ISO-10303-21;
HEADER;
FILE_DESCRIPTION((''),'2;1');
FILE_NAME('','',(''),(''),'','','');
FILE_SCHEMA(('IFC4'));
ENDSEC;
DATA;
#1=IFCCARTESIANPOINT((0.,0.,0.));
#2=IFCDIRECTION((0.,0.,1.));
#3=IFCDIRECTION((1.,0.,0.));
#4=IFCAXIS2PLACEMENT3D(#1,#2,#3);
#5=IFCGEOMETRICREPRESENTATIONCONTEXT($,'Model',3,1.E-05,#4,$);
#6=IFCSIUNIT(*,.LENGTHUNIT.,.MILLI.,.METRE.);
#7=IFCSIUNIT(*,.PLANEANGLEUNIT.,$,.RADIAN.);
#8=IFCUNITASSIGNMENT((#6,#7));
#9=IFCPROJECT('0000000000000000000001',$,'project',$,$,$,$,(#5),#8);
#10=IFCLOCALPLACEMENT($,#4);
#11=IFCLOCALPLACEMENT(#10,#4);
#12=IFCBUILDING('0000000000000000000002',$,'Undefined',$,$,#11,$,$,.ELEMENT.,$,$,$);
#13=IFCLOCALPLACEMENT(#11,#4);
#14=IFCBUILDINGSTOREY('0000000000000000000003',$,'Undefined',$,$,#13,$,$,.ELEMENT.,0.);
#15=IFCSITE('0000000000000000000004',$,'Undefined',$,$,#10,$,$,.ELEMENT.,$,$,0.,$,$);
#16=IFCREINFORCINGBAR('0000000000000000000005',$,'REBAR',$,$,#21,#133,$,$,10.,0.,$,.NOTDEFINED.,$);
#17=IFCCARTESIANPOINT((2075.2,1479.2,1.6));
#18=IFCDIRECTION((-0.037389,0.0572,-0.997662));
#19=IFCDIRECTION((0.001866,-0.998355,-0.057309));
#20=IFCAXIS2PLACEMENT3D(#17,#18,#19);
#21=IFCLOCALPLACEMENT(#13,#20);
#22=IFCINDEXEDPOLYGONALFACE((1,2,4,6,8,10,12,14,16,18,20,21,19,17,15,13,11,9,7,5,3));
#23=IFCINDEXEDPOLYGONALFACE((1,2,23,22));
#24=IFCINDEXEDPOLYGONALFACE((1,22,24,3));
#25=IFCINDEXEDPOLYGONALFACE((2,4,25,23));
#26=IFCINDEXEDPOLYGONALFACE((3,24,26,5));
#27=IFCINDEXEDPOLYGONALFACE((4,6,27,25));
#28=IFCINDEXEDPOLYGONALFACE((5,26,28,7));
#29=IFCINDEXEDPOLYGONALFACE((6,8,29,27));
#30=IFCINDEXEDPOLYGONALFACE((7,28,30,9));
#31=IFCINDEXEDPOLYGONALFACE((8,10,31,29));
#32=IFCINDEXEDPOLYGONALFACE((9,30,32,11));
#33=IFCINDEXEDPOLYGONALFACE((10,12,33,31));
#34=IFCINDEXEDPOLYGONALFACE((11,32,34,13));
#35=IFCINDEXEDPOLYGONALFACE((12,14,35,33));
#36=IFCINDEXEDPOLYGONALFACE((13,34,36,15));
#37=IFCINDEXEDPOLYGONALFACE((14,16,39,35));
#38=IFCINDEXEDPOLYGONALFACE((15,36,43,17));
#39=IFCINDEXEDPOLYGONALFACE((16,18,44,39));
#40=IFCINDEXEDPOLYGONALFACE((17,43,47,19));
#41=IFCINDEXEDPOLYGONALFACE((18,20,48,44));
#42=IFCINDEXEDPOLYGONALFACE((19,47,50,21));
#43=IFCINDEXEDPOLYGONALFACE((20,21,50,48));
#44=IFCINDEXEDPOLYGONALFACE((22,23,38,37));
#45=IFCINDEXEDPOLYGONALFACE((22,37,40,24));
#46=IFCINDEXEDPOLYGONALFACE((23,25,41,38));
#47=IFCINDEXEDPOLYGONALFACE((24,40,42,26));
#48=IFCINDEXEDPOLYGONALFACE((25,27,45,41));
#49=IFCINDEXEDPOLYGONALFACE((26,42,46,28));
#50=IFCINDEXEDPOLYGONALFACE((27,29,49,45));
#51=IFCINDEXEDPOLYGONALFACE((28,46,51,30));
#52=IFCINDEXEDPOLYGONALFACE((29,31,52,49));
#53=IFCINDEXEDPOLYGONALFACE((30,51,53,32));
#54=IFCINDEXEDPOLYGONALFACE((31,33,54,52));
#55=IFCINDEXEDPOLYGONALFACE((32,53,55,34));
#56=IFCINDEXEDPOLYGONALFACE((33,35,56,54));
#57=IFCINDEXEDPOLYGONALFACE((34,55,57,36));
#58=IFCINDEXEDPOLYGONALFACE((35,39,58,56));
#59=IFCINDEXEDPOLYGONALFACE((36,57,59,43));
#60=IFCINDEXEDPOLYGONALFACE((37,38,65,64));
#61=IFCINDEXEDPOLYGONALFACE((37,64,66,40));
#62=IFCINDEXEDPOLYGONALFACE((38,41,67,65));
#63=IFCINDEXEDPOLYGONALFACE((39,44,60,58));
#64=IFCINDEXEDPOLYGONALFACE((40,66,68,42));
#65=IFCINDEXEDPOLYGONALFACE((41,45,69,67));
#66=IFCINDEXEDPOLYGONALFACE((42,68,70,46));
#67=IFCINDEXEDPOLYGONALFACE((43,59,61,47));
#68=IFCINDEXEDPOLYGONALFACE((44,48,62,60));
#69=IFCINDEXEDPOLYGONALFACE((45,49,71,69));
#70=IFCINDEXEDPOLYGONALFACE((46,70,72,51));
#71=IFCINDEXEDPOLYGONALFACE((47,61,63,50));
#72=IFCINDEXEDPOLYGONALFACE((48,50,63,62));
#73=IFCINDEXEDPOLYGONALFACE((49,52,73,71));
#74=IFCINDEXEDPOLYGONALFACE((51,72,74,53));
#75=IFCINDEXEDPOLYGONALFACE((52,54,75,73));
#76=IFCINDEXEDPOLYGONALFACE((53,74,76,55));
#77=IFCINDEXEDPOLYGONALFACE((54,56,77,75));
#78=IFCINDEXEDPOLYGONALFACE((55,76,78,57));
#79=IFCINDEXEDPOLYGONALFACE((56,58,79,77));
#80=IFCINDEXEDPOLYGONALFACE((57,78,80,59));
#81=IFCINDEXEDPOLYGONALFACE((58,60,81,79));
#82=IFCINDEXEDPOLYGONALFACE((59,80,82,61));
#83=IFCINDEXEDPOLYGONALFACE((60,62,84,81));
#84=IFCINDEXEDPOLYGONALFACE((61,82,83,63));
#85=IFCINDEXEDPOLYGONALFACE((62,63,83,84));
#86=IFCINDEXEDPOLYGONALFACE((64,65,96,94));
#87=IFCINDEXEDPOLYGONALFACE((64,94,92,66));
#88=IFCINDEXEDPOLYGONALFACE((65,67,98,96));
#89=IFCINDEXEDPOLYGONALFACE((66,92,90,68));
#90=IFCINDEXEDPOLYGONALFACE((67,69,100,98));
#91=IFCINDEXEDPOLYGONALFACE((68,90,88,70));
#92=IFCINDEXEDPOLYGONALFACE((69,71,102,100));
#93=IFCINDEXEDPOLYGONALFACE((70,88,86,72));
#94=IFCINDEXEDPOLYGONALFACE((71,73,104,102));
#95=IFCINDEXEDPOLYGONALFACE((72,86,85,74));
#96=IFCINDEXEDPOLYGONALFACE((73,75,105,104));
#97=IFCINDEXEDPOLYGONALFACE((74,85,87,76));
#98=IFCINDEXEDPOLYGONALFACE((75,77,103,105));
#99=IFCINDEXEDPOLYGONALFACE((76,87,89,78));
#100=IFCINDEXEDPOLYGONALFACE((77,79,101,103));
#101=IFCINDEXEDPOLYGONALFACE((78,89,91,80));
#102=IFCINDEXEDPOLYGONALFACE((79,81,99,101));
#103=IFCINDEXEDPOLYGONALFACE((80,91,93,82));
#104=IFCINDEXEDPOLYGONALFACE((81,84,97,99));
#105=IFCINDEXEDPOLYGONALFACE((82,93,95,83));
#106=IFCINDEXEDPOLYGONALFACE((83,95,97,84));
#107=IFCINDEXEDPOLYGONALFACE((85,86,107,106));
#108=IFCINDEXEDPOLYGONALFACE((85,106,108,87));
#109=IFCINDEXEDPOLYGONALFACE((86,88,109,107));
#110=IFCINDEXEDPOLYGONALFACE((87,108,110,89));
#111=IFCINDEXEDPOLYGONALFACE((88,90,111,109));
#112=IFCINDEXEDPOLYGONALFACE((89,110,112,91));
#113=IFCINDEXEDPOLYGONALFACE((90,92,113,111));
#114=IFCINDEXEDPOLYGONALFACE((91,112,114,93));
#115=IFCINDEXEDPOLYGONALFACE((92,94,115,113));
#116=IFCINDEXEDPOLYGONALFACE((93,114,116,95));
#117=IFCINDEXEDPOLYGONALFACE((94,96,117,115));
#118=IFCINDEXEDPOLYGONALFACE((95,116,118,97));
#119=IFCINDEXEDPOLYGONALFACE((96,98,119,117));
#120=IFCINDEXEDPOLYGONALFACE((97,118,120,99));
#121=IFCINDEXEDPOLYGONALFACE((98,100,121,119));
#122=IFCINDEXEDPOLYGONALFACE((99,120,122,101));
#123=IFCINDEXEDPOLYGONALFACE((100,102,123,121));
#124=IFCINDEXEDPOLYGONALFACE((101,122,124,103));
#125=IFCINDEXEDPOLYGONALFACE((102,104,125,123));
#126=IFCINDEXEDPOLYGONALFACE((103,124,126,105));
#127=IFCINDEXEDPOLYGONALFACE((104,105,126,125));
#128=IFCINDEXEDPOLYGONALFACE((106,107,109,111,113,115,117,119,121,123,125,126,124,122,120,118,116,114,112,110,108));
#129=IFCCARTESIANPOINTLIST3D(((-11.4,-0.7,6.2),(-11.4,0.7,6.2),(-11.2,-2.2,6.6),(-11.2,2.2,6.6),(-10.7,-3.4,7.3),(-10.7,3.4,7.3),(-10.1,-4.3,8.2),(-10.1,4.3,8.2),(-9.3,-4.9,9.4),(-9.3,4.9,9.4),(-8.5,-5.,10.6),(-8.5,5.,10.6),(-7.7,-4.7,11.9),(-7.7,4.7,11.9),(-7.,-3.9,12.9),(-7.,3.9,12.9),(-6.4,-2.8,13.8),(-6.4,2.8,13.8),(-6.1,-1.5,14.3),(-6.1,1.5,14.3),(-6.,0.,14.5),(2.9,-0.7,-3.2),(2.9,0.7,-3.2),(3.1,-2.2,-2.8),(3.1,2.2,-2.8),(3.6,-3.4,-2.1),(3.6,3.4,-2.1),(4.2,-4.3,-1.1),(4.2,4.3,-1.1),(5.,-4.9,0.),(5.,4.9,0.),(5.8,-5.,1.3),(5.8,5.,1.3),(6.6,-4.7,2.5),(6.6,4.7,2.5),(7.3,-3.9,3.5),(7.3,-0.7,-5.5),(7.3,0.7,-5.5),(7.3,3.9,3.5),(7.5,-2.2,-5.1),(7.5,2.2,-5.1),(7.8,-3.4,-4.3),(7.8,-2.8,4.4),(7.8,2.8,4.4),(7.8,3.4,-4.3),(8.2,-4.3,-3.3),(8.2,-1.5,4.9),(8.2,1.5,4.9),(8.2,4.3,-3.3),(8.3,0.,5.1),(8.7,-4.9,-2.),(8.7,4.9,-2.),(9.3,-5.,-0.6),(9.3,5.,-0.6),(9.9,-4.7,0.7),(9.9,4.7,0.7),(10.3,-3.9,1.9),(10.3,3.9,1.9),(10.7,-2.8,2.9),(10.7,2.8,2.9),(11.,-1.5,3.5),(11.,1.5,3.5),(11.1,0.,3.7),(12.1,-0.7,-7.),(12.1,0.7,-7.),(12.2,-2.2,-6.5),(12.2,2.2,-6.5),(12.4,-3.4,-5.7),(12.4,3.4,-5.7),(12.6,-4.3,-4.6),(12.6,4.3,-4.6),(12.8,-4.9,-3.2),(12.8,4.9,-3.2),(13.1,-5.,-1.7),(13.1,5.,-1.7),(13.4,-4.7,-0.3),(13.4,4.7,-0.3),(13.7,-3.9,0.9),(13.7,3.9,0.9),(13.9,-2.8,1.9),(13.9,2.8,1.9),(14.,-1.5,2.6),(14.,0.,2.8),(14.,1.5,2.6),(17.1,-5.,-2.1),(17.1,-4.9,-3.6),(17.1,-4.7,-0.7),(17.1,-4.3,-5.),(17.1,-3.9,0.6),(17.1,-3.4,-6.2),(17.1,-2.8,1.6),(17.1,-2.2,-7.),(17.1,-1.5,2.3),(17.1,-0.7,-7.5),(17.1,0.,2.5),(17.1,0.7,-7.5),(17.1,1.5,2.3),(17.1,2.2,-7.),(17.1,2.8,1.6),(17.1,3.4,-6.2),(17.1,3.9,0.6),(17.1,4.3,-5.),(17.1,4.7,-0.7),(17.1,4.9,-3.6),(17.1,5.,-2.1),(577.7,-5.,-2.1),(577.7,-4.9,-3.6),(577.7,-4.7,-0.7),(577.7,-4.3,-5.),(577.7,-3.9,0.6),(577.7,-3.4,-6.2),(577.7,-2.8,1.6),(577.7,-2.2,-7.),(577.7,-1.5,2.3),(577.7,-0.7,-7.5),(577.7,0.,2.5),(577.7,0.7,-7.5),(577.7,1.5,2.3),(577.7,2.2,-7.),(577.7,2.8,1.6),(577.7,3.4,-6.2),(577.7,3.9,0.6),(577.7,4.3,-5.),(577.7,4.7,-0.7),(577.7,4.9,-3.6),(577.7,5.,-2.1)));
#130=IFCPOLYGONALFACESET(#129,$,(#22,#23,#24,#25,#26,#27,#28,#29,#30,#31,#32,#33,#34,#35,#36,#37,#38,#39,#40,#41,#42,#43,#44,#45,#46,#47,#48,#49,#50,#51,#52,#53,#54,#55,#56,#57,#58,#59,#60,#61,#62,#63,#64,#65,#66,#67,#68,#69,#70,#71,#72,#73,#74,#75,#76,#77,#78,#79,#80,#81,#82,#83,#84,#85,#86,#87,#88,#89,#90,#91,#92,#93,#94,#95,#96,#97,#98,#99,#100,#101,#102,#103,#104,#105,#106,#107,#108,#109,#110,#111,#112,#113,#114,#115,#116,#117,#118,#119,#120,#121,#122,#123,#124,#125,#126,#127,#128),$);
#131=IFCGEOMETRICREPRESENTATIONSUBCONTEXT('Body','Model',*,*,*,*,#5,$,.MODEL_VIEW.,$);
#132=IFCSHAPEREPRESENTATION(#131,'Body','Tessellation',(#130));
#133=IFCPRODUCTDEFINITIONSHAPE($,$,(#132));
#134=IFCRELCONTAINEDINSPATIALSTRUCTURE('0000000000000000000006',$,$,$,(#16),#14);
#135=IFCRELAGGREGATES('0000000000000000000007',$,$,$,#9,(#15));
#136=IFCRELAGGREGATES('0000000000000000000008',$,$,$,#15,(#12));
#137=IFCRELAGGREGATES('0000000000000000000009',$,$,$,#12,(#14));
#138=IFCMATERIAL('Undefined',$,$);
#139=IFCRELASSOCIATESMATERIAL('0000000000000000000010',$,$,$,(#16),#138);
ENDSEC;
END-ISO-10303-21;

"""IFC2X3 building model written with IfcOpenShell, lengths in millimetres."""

from ifc_helpers import new_model, entity, si_unit, frame, origin_with_axes, place, context, subcontext, project, spatial, source, transform, mapped, material, element, save


model = new_model("IFC2X3")

# Units and contexts
model_context = context("Model", 3, precision=1e-05, world=origin_with_axes())
body_context = subcontext(model_context, "Body", "Model", "MODEL_VIEW")
ifc_project = project(units=[si_unit("LENGTHUNIT", "METRE", prefix="MILLI"), si_unit("PLANEANGLEUNIT", "RADIAN")], contexts=[model_context])

# Site, building, storey
site_placement = place(None, origin_with_axes())
site = spatial("IfcSite", under=ifc_project, at=site_placement, Name="Undefined", CompositionType="ELEMENT", RefElevation=0.0)
building_placement = place(site_placement, origin_with_axes())
building = spatial("IfcBuilding", under=site, at=building_placement, Name="Undefined", CompositionType="ELEMENT")
storey_placement = place(building_placement, origin_with_axes())
storey = spatial("IfcBuildingStorey", under=building, at=storey_placement, Name="Undefined", CompositionType="ELEMENT", Elevation=0.0)

# Reinforcing bar
ifc_material_1 = material(Name="Undefined")
shared_shape_1 = source(origin_with_axes(), body_context, "Body", "AdvancedSweptSolid", [
    entity("IfcSweptDiskSolid", entity("IfcCompositeCurve", [entity("IfcCompositeCurveSegment", "CONTINUOUS", True, entity("IfcTrimmedCurve", entity("IfcLine", entity("IfcCartesianPoint", [0.0, 0.0, 0.0]), entity("IfcVector", entity("IfcDirection", [0.835483, 0.0, -0.549516]), 1.0)), [entity("IfcParameterValue", 0.0)], [entity("IfcParameterValue", 17.082101)], True, "PARAMETER")), entity("IfcCompositeCurveSegment", "CONTINUOUS", True, entity("IfcTrimmedCurve", entity("IfcCircle", entity("IfcAxis2Placement3D", entity("IfcCartesianPoint", [25.8, 0.0, 8.2]), entity("IfcDirection", [0.0, -1.0, 0.0]), entity("IfcDirection", [-0.549516, 0.0, -0.835483])), 21.0), [entity("IfcParameterValue", 0.0)], [entity("IfcParameterValue", 0.581785)], True, "PARAMETER")), entity("IfcCompositeCurveSegment", "DISCONTINUOUS", True, entity("IfcTrimmedCurve", entity("IfcLine", entity("IfcCartesianPoint", [25.8, 0.0, -12.8]), entity("IfcVector", entity("IfcDirection", [1.0, 0.0, 0.0]), 1.0)), [entity("IfcParameterValue", 0.0)], [entity("IfcParameterValue", 560.593055)], True, "PARAMETER"))], False), 5.0, None, 0.0, 578.3),
])
reinforcing_bar_1_placement = place(storey_placement, frame((2075.2, 1479.2, 1.6), z_axis=(-0.037389, 0.0572, -0.997662), x_axis=(0.001866, -0.998355, -0.057309)))
element("IfcReinforcingBar", 1, at=reinforcing_bar_1_placement, inside=storey, material=ifc_material_1, Name="REBAR", BarRole="NOTDEFINED", CrossSectionArea=0.0, NominalDiameter=10.0, context=body_context, shape_type="MappedRepresentation", body=[
    mapped(shared_shape_1, transform((-8.7, 0.0, 10.3))),
])

save(model, "model.ifc")
